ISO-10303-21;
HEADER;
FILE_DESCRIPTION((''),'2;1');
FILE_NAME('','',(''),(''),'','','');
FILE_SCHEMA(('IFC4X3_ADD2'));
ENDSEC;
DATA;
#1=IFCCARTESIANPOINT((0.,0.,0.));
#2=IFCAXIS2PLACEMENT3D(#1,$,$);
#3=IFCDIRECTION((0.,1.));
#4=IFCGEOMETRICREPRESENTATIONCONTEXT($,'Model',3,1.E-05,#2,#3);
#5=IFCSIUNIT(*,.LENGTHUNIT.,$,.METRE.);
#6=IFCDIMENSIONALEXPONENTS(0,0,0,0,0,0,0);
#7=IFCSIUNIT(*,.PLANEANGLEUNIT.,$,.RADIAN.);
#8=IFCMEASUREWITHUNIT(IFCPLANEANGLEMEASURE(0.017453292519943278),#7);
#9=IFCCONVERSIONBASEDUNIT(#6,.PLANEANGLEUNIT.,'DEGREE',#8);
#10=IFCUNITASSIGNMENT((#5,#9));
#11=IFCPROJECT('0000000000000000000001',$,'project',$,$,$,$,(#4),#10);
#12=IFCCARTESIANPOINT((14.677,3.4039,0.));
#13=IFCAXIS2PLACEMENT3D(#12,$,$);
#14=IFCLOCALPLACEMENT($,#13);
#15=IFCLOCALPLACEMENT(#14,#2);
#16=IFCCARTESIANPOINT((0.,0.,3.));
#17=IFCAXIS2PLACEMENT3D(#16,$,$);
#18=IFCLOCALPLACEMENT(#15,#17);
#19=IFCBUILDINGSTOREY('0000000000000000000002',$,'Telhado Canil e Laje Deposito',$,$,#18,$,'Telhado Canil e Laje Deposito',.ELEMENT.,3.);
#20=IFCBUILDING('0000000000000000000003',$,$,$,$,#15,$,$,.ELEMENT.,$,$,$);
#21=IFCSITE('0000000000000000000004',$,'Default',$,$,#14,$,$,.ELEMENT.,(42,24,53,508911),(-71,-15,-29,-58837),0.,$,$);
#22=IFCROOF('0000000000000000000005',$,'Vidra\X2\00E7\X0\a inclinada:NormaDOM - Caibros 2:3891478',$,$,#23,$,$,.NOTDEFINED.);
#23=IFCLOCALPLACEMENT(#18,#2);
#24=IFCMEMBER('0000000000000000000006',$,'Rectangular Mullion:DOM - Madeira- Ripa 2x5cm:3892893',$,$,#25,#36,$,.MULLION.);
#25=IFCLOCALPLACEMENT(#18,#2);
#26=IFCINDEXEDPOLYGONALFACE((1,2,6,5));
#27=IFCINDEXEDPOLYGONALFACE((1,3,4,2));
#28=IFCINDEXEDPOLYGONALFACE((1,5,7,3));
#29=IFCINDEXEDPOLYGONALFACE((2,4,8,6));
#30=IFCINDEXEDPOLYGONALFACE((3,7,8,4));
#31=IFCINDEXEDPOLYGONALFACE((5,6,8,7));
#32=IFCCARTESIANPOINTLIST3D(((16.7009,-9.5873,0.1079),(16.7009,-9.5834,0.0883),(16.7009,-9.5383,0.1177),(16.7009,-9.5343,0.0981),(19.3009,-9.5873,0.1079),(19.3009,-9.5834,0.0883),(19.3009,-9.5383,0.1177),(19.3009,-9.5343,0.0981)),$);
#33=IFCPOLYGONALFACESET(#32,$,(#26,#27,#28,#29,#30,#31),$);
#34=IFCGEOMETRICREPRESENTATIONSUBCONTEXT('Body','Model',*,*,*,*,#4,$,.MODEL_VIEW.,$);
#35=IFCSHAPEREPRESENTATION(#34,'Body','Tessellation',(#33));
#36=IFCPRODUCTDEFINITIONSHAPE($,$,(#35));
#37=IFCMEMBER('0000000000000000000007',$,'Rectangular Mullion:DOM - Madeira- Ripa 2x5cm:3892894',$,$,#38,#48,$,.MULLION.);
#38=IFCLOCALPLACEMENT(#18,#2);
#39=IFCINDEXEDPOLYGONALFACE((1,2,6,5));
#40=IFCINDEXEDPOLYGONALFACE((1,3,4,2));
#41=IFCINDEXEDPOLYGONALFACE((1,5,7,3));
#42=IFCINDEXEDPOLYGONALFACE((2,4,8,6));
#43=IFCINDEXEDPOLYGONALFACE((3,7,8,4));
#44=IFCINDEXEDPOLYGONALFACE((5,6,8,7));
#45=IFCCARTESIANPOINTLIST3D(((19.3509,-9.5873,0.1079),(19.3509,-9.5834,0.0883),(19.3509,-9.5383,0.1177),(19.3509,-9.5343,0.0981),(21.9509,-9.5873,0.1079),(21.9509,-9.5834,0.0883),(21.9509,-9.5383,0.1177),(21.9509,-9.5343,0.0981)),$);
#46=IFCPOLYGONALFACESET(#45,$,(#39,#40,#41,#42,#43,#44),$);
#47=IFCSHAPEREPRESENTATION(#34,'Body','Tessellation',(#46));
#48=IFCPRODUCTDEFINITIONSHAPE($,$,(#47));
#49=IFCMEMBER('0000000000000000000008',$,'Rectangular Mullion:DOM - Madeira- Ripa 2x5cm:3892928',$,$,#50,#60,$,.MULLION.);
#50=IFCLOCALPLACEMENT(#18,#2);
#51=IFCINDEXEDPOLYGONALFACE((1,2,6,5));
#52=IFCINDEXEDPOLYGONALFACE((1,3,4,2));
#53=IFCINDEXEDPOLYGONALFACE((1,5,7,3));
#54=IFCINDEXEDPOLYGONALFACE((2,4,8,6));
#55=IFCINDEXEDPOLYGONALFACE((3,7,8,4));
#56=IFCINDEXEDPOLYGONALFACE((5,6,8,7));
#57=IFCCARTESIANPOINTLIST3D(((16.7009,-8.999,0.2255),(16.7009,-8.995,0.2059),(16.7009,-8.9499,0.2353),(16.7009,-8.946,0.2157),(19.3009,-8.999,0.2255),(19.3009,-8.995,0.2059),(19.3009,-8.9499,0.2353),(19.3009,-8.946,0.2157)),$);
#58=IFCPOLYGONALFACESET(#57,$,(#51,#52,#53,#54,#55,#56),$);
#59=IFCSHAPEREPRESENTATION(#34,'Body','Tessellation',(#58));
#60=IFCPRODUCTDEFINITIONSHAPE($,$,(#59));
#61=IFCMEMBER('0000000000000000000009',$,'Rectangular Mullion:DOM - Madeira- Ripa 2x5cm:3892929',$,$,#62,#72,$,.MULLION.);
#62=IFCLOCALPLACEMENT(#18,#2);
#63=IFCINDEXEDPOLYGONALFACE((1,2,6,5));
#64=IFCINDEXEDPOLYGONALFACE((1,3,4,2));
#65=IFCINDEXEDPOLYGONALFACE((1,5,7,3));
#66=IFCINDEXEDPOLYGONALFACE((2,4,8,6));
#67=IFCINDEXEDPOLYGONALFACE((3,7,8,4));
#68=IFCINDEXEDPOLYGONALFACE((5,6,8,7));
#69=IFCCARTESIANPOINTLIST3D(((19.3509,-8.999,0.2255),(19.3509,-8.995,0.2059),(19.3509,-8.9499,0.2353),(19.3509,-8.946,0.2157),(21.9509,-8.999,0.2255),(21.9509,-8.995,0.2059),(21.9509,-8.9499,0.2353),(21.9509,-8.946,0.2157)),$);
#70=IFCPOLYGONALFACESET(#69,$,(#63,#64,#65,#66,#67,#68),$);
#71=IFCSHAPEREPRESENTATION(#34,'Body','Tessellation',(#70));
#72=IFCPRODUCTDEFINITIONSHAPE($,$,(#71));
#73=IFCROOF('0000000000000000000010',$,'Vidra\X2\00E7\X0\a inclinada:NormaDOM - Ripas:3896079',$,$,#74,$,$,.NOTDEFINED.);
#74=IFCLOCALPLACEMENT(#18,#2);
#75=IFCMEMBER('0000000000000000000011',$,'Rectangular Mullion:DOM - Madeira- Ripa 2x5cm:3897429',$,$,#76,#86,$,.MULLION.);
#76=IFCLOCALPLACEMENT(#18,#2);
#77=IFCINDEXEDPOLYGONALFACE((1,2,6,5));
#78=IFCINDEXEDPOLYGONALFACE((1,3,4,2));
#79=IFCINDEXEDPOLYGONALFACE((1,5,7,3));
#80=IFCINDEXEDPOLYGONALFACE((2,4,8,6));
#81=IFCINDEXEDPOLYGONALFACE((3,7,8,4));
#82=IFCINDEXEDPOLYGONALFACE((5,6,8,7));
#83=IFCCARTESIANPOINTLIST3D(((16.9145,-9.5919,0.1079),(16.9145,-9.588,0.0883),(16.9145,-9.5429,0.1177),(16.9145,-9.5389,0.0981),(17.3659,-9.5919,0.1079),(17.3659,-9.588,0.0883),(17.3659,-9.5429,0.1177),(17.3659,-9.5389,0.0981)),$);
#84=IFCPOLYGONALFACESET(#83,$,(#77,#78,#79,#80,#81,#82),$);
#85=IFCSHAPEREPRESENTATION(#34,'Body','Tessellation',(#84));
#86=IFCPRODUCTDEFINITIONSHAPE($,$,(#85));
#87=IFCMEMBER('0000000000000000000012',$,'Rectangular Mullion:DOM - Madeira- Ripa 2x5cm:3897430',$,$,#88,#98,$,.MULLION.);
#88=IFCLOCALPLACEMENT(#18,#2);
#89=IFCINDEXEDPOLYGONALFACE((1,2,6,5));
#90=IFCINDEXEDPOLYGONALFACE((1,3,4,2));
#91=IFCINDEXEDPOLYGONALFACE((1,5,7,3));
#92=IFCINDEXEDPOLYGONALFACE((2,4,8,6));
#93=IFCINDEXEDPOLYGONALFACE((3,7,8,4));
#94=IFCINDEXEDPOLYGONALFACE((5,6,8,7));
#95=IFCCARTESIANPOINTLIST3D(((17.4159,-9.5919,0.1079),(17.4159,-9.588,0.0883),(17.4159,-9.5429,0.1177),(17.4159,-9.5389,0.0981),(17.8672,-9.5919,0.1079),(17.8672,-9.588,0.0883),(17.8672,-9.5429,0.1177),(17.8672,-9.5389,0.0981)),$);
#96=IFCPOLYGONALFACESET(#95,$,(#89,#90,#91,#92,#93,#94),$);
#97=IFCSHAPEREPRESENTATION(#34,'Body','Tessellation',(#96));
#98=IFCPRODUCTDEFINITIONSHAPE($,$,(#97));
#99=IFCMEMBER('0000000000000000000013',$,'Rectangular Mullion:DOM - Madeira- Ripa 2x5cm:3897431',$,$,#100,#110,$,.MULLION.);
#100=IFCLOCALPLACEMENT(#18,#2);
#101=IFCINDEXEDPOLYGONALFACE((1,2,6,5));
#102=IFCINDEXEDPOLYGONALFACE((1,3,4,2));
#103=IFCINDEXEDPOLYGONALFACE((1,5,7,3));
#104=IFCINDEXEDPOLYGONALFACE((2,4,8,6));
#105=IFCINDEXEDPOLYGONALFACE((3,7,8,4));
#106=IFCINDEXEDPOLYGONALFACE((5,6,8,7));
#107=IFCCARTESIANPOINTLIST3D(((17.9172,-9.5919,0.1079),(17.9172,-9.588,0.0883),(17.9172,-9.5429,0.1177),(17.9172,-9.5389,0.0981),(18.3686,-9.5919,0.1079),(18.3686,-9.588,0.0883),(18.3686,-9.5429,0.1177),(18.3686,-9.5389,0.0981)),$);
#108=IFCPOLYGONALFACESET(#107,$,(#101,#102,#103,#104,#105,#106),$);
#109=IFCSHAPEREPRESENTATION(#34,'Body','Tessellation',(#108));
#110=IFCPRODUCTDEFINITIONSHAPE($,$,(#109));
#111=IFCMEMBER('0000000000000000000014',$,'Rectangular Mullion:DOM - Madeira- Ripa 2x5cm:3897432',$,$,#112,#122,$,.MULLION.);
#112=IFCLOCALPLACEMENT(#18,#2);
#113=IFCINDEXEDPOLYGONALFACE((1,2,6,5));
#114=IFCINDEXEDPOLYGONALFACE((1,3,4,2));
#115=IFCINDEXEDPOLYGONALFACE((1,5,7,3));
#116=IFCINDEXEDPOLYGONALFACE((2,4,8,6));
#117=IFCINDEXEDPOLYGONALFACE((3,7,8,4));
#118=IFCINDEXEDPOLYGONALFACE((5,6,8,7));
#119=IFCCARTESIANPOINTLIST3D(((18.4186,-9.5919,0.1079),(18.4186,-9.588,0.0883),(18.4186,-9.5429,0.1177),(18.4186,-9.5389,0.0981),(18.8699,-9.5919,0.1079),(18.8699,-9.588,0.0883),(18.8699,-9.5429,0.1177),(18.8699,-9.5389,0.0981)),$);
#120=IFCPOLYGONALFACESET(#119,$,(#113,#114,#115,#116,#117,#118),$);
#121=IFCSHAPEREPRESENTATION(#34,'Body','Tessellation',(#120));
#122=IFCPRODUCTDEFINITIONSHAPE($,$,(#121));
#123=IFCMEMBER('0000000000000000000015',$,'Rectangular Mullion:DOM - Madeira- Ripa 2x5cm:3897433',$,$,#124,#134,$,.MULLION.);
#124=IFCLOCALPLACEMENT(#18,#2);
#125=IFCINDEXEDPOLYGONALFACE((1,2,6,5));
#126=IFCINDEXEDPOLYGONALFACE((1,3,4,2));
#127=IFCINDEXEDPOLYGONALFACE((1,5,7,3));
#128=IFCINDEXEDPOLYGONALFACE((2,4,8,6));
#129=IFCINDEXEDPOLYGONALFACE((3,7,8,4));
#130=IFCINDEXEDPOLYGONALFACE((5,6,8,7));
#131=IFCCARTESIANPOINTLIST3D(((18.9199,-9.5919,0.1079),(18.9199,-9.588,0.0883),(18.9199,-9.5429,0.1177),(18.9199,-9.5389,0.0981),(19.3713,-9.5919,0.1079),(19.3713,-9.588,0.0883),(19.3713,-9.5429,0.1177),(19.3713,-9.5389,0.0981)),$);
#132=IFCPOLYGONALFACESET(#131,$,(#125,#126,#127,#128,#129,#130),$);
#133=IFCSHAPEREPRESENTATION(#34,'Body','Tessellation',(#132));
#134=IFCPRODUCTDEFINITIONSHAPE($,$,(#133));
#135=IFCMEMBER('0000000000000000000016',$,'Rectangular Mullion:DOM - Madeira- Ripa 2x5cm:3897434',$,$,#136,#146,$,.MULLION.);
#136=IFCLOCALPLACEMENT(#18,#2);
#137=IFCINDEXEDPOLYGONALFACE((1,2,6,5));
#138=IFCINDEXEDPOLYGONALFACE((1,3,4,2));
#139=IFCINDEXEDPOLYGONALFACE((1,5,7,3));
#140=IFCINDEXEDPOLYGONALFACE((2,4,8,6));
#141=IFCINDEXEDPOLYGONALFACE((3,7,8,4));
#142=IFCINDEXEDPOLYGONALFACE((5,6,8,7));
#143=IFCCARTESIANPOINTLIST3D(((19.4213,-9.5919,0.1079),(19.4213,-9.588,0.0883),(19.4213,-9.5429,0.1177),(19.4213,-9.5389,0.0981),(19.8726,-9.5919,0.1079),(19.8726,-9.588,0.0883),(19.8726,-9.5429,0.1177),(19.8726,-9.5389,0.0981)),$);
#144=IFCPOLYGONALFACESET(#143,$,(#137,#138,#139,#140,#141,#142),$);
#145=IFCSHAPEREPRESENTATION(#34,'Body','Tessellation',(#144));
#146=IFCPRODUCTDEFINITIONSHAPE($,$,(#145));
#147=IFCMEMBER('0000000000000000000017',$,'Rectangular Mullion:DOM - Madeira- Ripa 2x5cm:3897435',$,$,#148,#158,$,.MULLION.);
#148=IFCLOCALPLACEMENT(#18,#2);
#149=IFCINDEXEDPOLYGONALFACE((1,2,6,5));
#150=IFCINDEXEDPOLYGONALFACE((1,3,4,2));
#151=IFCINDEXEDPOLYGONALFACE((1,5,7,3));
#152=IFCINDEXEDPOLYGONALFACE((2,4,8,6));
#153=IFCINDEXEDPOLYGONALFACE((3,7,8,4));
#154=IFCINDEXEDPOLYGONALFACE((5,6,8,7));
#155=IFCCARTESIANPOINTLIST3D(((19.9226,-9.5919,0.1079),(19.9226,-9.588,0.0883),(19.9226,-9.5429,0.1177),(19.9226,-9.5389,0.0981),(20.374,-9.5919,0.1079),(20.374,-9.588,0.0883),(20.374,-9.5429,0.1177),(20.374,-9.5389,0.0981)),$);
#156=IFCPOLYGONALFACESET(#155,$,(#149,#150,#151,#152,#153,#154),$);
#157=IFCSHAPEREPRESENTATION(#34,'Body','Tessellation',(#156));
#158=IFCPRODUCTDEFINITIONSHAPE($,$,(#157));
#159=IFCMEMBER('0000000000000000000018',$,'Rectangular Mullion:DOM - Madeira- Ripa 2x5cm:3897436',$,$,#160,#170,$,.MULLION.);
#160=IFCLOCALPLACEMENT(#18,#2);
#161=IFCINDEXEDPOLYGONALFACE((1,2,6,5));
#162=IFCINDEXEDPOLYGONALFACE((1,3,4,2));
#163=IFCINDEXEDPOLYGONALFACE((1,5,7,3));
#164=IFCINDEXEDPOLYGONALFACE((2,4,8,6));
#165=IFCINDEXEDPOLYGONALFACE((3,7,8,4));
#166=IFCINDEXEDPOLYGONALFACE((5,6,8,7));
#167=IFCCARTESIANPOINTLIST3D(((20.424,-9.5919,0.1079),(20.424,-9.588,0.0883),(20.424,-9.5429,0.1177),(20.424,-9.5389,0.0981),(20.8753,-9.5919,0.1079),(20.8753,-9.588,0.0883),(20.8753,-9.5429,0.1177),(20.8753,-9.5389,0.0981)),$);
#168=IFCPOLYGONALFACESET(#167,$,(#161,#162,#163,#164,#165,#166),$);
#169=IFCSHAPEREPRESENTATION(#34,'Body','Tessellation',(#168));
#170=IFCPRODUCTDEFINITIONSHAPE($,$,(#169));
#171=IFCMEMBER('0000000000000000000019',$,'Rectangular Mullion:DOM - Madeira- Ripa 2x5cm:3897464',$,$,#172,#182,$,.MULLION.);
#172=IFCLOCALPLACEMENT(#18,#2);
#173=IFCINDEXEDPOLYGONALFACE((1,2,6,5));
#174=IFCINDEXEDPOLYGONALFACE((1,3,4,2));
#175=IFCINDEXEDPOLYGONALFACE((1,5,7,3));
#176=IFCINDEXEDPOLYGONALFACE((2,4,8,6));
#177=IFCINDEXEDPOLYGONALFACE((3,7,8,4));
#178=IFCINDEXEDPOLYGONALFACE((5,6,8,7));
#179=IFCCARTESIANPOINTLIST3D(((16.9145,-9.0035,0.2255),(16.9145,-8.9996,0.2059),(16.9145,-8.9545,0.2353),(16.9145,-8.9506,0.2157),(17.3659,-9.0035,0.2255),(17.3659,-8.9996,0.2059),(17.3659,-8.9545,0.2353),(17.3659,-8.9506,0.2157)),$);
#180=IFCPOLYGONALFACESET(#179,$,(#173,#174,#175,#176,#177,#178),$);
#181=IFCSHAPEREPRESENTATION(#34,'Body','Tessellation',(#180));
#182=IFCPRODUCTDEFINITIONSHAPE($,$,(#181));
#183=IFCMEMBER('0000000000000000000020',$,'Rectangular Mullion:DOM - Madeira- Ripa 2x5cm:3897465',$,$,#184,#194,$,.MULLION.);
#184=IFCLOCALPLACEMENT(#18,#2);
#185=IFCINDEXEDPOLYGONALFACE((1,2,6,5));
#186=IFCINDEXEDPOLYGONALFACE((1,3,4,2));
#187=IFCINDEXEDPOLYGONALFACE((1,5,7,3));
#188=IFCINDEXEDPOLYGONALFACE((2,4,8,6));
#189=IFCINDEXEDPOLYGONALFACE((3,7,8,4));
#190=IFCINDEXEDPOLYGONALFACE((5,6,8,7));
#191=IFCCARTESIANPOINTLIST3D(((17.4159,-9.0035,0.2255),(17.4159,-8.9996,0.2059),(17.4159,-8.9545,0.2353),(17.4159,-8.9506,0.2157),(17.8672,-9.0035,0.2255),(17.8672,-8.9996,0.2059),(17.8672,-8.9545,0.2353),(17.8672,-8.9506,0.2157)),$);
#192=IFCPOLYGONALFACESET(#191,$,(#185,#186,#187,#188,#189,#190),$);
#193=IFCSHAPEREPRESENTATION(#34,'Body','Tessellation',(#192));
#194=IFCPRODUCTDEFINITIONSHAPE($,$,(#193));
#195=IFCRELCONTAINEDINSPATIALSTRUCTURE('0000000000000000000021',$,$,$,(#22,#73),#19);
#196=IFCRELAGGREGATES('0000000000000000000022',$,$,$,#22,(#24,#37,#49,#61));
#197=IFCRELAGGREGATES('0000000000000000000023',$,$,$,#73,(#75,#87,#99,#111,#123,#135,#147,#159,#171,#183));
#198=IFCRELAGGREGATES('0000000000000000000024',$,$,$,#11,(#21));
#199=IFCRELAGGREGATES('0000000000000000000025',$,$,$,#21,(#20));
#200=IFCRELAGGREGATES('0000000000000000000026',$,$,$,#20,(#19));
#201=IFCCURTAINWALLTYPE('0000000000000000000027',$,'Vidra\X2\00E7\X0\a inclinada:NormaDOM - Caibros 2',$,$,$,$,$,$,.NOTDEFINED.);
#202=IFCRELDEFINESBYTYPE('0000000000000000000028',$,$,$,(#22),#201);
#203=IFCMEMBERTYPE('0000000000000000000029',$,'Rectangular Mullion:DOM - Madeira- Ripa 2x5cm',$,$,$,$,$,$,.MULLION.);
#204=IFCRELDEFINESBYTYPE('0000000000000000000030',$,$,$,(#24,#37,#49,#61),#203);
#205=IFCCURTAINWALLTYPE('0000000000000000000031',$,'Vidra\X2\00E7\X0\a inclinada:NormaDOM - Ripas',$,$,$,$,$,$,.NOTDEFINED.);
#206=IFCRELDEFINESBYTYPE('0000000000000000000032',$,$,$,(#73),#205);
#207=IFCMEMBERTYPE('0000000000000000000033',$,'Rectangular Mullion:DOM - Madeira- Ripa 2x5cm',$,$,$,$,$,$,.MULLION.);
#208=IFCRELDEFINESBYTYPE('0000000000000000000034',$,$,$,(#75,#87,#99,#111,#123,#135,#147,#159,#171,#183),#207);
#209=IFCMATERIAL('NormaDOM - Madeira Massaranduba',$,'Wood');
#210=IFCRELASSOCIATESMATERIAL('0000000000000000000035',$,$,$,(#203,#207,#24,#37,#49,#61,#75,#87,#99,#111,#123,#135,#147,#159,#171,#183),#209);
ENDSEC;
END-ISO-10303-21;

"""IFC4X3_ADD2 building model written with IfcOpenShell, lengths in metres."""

from ifc_helpers import new_model, entity, si_unit, converted_unit, direction, frame, origin, origin_2d_with_axis, place, context, subcontext, project, spatial, rectangle, extrude, source, transform, mapped, material, material_profile, profile_set, profile_usage, type_object, type_shapes, element, aggregate, save


model = new_model("IFC4X3_ADD2")

# Units and contexts
model_context = context("Model", 3, precision=1e-05, world=origin(), true_north=direction((0.0, 1.0)))
body_context = subcontext(model_context, "Body", "Model", "MODEL_VIEW")
ifc_project = project(units=[si_unit("LENGTHUNIT", "METRE"), converted_unit("PLANEANGLEUNIT", "DEGREE", entity("IfcPlaneAngleMeasure", 0.017453292519943278), si_unit("PLANEANGLEUNIT", "RADIAN"), dimensions=[0, 0, 0, 0, 0, 0, 0])], contexts=[model_context])

# Site, building, storey
site_placement = place(None, frame((14.677, 3.4039, 0.0)))
site = spatial("IfcSite", under=ifc_project, at=site_placement, Name="Default", CompositionType="ELEMENT", RefLatitude=(42, 24, 53, 508911), RefLongitude=(-71, -15, -29, -58837), RefElevation=0.0)
building_placement = place(site_placement, origin())
building = spatial("IfcBuilding", under=site, at=building_placement, CompositionType="ELEMENT")
storey_placement = place(building_placement, frame((0.0, 0.0, 3.0)))
storey = spatial("IfcBuildingStorey", under=building, at=storey_placement, Name="Telhado Canil e Laje Deposito", LongName="Telhado Canil e Laje Deposito", CompositionType="ELEMENT", Elevation=3.0)

# Roofs, members
curtain_wall_type_1 = type_object("IfcCurtainWallType", Name="Vidraça inclinada:NormaDOM - Caibros 2", PredefinedType="NOTDEFINED")
roof_1_placement = place(storey_placement, frame((0.0, 0.0, -3.0)))
roof_1 = element("IfcRoof", 1, at=roof_1_placement, inside=storey, type_object=curtain_wall_type_1, Name="Vidraça inclinada:NormaDOM - Caibros 2:3891478", PredefinedType="NOTDEFINED")
ifc_material = material(Name="NormaDOM - Madeira Massaranduba", Category="Wood")
ifc_material_profile_1 = material_profile(ifc_material, rectangle(XDim=0.05, YDim=0.02, at=origin_2d_with_axis()), Name="DOM - Madeira- Ripa 2x5cm")
ifc_profile_set_1 = profile_set([ifc_material_profile_1], Name="DOM - Madeira- Ripa 2x5cm")
ifc_profile_usage_1 = profile_usage(ifc_profile_set_1)
member_type_1 = type_object("IfcMemberType", Name="Rectangular Mullion:DOM - Madeira- Ripa 2x5cm", PredefinedType="MULLION", material=ifc_profile_set_1)
shared_shape_1 = source(origin(), body_context, "Body", "SweptSolid", [
    extrude(rectangle(XDim=0.05, YDim=0.02, at=origin_2d_with_axis()), frame((0.025, 0.01, -2.6), z_axis=(0.0, 0.0, 1.0), x_axis=(-1.0, 0.0, 0.0)), (0.0, 0.0, 1.0), 2.6),
])
type_shapes(member_type_1, [shared_shape_1])
member_1_placement = place(roof_1_placement, frame((16.7009, -9.5873, 3.1079), z_axis=(-1.0, 0.0, 0.0), x_axis=(0.0, 0.980581, 0.196116)))
member_1 = element("IfcMember", 2, at=member_1_placement, type_object=member_type_1, material=ifc_profile_usage_1, Name="Rectangular Mullion:DOM - Madeira- Ripa 2x5cm:3892893", PredefinedType="MULLION", context=body_context, shape_type="MappedRepresentation", body=[
    mapped(shared_shape_1, transform((0.0, 0.0, 0.0), scale=1.0)),
])
member_2_placement = place(roof_1_placement, frame((19.3509, -9.5873, 3.1079), z_axis=(-1.0, 0.0, 0.0), x_axis=(0.0, 0.980581, 0.196116)))
member_2 = element("IfcMember", 3, at=member_2_placement, type_object=member_type_1, material=ifc_profile_usage_1, Name="Rectangular Mullion:DOM - Madeira- Ripa 2x5cm:3892894", PredefinedType="MULLION", context=body_context, shape_type="MappedRepresentation", body=[
    mapped(shared_shape_1, transform((0.0, 0.0, 0.0), scale=1.0)),
])
member_3_placement = place(roof_1_placement, frame((16.7009, -8.999, 3.2255), z_axis=(-1.0, 0.0, 0.0), x_axis=(0.0, 0.980581, 0.196116)))
member_3 = element("IfcMember", 4, at=member_3_placement, type_object=member_type_1, material=ifc_profile_usage_1, Name="Rectangular Mullion:DOM - Madeira- Ripa 2x5cm:3892928", PredefinedType="MULLION", context=body_context, shape_type="MappedRepresentation", body=[
    mapped(shared_shape_1, transform((0.0, 0.0, 0.0), scale=1.0)),
])
member_4_placement = place(roof_1_placement, frame((19.3509, -8.999, 3.2255), z_axis=(-1.0, 0.0, 0.0), x_axis=(0.0, 0.980581, 0.196116)))
member_4 = element("IfcMember", 5, at=member_4_placement, type_object=member_type_1, material=ifc_profile_usage_1, Name="Rectangular Mullion:DOM - Madeira- Ripa 2x5cm:3892929", PredefinedType="MULLION", context=body_context, shape_type="MappedRepresentation", body=[
    mapped(shared_shape_1, transform((0.0, 0.0, 0.0), scale=1.0)),
])
curtain_wall_type_2 = type_object("IfcCurtainWallType", Name="Vidraça inclinada:NormaDOM - Ripas", PredefinedType="NOTDEFINED")
roof_2_placement = place(storey_placement, frame((0.0, 0.0, -3.0)))
roof_2 = element("IfcRoof", 6, at=roof_2_placement, inside=storey, type_object=curtain_wall_type_2, Name="Vidraça inclinada:NormaDOM - Ripas:3896079", PredefinedType="NOTDEFINED")

# Members
aggregate(roof_1, [member_1, member_2, member_3, member_4])
member_type_2 = type_object("IfcMemberType", Name="Rectangular Mullion:DOM - Madeira- Ripa 2x5cm", PredefinedType="MULLION", material=ifc_profile_set_1)
shared_shape_2 = source(origin(), body_context, "Body", "SweptSolid", [
    extrude(rectangle(XDim=0.05, YDim=0.02, at=origin_2d_with_axis()), frame((0.025, 0.01, -0.4514), z_axis=(0.0, 0.0, 1.0), x_axis=(-1.0, 0.0, 0.0)), (0.0, 0.0, 1.0), 0.4514),
])
type_shapes(member_type_2, [shared_shape_2])
member_5_placement = place(roof_2_placement, frame((16.9145, -9.5919, 3.1079), z_axis=(-1.0, 0.0, 0.0), x_axis=(0.0, 0.980581, 0.196116)))
member_5 = element("IfcMember", 7, at=member_5_placement, type_object=member_type_2, material=ifc_profile_usage_1, Name="Rectangular Mullion:DOM - Madeira- Ripa 2x5cm:3897429", PredefinedType="MULLION", context=body_context, shape_type="MappedRepresentation", body=[
    mapped(shared_shape_2, transform((0.0, 0.0, 0.0), scale=1.0)),
])
member_6_placement = place(roof_2_placement, frame((17.4159, -9.5919, 3.1079), z_axis=(-1.0, 0.0, 0.0), x_axis=(0.0, 0.980581, 0.196116)))
member_6 = element("IfcMember", 8, at=member_6_placement, type_object=member_type_2, material=ifc_profile_usage_1, Name="Rectangular Mullion:DOM - Madeira- Ripa 2x5cm:3897430", PredefinedType="MULLION", context=body_context, shape_type="MappedRepresentation", body=[
    mapped(shared_shape_2, transform((0.0, 0.0, 0.0), scale=1.0)),
])
member_7_placement = place(roof_2_placement, frame((17.9172, -9.5919, 3.1079), z_axis=(-1.0, 0.0, 0.0), x_axis=(0.0, 0.980581, 0.196116)))
member_7 = element("IfcMember", 9, at=member_7_placement, type_object=member_type_2, material=ifc_profile_usage_1, Name="Rectangular Mullion:DOM - Madeira- Ripa 2x5cm:3897431", PredefinedType="MULLION", context=body_context, shape_type="MappedRepresentation", body=[
    mapped(shared_shape_2, transform((0.0, 0.0, 0.0), scale=1.0)),
])
member_8_placement = place(roof_2_placement, frame((18.4186, -9.5919, 3.1079), z_axis=(-1.0, 0.0, 0.0), x_axis=(0.0, 0.980581, 0.196116)))
member_8 = element("IfcMember", 10, at=member_8_placement, type_object=member_type_2, material=ifc_profile_usage_1, Name="Rectangular Mullion:DOM - Madeira- Ripa 2x5cm:3897432", PredefinedType="MULLION", context=body_context, shape_type="MappedRepresentation", body=[
    mapped(shared_shape_2, transform((0.0, 0.0, 0.0), scale=1.0)),
])
member_9_placement = place(roof_2_placement, frame((18.9199, -9.5919, 3.1079), z_axis=(-1.0, 0.0, 0.0), x_axis=(0.0, 0.980581, 0.196116)))
member_9 = element("IfcMember", 11, at=member_9_placement, type_object=member_type_2, material=ifc_profile_usage_1, Name="Rectangular Mullion:DOM - Madeira- Ripa 2x5cm:3897433", PredefinedType="MULLION", context=body_context, shape_type="MappedRepresentation", body=[
    mapped(shared_shape_2, transform((0.0, 0.0, 0.0), scale=1.0)),
])
member_10_placement = place(roof_2_placement, frame((19.4213, -9.5919, 3.1079), z_axis=(-1.0, 0.0, 0.0), x_axis=(0.0, 0.980581, 0.196116)))
member_10 = element("IfcMember", 12, at=member_10_placement, type_object=member_type_2, material=ifc_profile_usage_1, Name="Rectangular Mullion:DOM - Madeira- Ripa 2x5cm:3897434", PredefinedType="MULLION", context=body_context, shape_type="MappedRepresentation", body=[
    mapped(shared_shape_2, transform((0.0, 0.0, 0.0), scale=1.0)),
])
member_11_placement = place(roof_2_placement, frame((19.9226, -9.5919, 3.1079), z_axis=(-1.0, 0.0, 0.0), x_axis=(0.0, 0.980581, 0.196116)))
member_11 = element("IfcMember", 13, at=member_11_placement, type_object=member_type_2, material=ifc_profile_usage_1, Name="Rectangular Mullion:DOM - Madeira- Ripa 2x5cm:3897435", PredefinedType="MULLION", context=body_context, shape_type="MappedRepresentation", body=[
    mapped(shared_shape_2, transform((0.0, 0.0, 0.0), scale=1.0)),
])
member_12_placement = place(roof_2_placement, frame((20.424, -9.5919, 3.1079), z_axis=(-1.0, 0.0, 0.0), x_axis=(0.0, 0.980581, 0.196116)))
member_12 = element("IfcMember", 14, at=member_12_placement, type_object=member_type_2, material=ifc_profile_usage_1, Name="Rectangular Mullion:DOM - Madeira- Ripa 2x5cm:3897436", PredefinedType="MULLION", context=body_context, shape_type="MappedRepresentation", body=[
    mapped(shared_shape_2, transform((0.0, 0.0, 0.0), scale=1.0)),
])
member_13_placement = place(roof_2_placement, frame((16.9145, -9.0035, 3.2255), z_axis=(-1.0, 0.0, 0.0), x_axis=(0.0, 0.980581, 0.196116)))
member_13 = element("IfcMember", 15, at=member_13_placement, type_object=member_type_2, material=ifc_profile_usage_1, Name="Rectangular Mullion:DOM - Madeira- Ripa 2x5cm:3897464", PredefinedType="MULLION", context=body_context, shape_type="MappedRepresentation", body=[
    mapped(shared_shape_2, transform((0.0, 0.0, 0.0), scale=1.0)),
])
member_14_placement = place(roof_2_placement, frame((17.4159, -9.0035, 3.2255), z_axis=(-1.0, 0.0, 0.0), x_axis=(0.0, 0.980581, 0.196116)))
member_14 = element("IfcMember", 16, at=member_14_placement, type_object=member_type_2, material=ifc_profile_usage_1, Name="Rectangular Mullion:DOM - Madeira- Ripa 2x5cm:3897465", PredefinedType="MULLION", context=body_context, shape_type="MappedRepresentation", body=[
    mapped(shared_shape_2, transform((0.0, 0.0, 0.0), scale=1.0)),
])
aggregate(roof_2, [member_5, member_6, member_7, member_8, member_9, member_10, member_11, member_12, member_13, member_14])

save(model, "model.ifc")
